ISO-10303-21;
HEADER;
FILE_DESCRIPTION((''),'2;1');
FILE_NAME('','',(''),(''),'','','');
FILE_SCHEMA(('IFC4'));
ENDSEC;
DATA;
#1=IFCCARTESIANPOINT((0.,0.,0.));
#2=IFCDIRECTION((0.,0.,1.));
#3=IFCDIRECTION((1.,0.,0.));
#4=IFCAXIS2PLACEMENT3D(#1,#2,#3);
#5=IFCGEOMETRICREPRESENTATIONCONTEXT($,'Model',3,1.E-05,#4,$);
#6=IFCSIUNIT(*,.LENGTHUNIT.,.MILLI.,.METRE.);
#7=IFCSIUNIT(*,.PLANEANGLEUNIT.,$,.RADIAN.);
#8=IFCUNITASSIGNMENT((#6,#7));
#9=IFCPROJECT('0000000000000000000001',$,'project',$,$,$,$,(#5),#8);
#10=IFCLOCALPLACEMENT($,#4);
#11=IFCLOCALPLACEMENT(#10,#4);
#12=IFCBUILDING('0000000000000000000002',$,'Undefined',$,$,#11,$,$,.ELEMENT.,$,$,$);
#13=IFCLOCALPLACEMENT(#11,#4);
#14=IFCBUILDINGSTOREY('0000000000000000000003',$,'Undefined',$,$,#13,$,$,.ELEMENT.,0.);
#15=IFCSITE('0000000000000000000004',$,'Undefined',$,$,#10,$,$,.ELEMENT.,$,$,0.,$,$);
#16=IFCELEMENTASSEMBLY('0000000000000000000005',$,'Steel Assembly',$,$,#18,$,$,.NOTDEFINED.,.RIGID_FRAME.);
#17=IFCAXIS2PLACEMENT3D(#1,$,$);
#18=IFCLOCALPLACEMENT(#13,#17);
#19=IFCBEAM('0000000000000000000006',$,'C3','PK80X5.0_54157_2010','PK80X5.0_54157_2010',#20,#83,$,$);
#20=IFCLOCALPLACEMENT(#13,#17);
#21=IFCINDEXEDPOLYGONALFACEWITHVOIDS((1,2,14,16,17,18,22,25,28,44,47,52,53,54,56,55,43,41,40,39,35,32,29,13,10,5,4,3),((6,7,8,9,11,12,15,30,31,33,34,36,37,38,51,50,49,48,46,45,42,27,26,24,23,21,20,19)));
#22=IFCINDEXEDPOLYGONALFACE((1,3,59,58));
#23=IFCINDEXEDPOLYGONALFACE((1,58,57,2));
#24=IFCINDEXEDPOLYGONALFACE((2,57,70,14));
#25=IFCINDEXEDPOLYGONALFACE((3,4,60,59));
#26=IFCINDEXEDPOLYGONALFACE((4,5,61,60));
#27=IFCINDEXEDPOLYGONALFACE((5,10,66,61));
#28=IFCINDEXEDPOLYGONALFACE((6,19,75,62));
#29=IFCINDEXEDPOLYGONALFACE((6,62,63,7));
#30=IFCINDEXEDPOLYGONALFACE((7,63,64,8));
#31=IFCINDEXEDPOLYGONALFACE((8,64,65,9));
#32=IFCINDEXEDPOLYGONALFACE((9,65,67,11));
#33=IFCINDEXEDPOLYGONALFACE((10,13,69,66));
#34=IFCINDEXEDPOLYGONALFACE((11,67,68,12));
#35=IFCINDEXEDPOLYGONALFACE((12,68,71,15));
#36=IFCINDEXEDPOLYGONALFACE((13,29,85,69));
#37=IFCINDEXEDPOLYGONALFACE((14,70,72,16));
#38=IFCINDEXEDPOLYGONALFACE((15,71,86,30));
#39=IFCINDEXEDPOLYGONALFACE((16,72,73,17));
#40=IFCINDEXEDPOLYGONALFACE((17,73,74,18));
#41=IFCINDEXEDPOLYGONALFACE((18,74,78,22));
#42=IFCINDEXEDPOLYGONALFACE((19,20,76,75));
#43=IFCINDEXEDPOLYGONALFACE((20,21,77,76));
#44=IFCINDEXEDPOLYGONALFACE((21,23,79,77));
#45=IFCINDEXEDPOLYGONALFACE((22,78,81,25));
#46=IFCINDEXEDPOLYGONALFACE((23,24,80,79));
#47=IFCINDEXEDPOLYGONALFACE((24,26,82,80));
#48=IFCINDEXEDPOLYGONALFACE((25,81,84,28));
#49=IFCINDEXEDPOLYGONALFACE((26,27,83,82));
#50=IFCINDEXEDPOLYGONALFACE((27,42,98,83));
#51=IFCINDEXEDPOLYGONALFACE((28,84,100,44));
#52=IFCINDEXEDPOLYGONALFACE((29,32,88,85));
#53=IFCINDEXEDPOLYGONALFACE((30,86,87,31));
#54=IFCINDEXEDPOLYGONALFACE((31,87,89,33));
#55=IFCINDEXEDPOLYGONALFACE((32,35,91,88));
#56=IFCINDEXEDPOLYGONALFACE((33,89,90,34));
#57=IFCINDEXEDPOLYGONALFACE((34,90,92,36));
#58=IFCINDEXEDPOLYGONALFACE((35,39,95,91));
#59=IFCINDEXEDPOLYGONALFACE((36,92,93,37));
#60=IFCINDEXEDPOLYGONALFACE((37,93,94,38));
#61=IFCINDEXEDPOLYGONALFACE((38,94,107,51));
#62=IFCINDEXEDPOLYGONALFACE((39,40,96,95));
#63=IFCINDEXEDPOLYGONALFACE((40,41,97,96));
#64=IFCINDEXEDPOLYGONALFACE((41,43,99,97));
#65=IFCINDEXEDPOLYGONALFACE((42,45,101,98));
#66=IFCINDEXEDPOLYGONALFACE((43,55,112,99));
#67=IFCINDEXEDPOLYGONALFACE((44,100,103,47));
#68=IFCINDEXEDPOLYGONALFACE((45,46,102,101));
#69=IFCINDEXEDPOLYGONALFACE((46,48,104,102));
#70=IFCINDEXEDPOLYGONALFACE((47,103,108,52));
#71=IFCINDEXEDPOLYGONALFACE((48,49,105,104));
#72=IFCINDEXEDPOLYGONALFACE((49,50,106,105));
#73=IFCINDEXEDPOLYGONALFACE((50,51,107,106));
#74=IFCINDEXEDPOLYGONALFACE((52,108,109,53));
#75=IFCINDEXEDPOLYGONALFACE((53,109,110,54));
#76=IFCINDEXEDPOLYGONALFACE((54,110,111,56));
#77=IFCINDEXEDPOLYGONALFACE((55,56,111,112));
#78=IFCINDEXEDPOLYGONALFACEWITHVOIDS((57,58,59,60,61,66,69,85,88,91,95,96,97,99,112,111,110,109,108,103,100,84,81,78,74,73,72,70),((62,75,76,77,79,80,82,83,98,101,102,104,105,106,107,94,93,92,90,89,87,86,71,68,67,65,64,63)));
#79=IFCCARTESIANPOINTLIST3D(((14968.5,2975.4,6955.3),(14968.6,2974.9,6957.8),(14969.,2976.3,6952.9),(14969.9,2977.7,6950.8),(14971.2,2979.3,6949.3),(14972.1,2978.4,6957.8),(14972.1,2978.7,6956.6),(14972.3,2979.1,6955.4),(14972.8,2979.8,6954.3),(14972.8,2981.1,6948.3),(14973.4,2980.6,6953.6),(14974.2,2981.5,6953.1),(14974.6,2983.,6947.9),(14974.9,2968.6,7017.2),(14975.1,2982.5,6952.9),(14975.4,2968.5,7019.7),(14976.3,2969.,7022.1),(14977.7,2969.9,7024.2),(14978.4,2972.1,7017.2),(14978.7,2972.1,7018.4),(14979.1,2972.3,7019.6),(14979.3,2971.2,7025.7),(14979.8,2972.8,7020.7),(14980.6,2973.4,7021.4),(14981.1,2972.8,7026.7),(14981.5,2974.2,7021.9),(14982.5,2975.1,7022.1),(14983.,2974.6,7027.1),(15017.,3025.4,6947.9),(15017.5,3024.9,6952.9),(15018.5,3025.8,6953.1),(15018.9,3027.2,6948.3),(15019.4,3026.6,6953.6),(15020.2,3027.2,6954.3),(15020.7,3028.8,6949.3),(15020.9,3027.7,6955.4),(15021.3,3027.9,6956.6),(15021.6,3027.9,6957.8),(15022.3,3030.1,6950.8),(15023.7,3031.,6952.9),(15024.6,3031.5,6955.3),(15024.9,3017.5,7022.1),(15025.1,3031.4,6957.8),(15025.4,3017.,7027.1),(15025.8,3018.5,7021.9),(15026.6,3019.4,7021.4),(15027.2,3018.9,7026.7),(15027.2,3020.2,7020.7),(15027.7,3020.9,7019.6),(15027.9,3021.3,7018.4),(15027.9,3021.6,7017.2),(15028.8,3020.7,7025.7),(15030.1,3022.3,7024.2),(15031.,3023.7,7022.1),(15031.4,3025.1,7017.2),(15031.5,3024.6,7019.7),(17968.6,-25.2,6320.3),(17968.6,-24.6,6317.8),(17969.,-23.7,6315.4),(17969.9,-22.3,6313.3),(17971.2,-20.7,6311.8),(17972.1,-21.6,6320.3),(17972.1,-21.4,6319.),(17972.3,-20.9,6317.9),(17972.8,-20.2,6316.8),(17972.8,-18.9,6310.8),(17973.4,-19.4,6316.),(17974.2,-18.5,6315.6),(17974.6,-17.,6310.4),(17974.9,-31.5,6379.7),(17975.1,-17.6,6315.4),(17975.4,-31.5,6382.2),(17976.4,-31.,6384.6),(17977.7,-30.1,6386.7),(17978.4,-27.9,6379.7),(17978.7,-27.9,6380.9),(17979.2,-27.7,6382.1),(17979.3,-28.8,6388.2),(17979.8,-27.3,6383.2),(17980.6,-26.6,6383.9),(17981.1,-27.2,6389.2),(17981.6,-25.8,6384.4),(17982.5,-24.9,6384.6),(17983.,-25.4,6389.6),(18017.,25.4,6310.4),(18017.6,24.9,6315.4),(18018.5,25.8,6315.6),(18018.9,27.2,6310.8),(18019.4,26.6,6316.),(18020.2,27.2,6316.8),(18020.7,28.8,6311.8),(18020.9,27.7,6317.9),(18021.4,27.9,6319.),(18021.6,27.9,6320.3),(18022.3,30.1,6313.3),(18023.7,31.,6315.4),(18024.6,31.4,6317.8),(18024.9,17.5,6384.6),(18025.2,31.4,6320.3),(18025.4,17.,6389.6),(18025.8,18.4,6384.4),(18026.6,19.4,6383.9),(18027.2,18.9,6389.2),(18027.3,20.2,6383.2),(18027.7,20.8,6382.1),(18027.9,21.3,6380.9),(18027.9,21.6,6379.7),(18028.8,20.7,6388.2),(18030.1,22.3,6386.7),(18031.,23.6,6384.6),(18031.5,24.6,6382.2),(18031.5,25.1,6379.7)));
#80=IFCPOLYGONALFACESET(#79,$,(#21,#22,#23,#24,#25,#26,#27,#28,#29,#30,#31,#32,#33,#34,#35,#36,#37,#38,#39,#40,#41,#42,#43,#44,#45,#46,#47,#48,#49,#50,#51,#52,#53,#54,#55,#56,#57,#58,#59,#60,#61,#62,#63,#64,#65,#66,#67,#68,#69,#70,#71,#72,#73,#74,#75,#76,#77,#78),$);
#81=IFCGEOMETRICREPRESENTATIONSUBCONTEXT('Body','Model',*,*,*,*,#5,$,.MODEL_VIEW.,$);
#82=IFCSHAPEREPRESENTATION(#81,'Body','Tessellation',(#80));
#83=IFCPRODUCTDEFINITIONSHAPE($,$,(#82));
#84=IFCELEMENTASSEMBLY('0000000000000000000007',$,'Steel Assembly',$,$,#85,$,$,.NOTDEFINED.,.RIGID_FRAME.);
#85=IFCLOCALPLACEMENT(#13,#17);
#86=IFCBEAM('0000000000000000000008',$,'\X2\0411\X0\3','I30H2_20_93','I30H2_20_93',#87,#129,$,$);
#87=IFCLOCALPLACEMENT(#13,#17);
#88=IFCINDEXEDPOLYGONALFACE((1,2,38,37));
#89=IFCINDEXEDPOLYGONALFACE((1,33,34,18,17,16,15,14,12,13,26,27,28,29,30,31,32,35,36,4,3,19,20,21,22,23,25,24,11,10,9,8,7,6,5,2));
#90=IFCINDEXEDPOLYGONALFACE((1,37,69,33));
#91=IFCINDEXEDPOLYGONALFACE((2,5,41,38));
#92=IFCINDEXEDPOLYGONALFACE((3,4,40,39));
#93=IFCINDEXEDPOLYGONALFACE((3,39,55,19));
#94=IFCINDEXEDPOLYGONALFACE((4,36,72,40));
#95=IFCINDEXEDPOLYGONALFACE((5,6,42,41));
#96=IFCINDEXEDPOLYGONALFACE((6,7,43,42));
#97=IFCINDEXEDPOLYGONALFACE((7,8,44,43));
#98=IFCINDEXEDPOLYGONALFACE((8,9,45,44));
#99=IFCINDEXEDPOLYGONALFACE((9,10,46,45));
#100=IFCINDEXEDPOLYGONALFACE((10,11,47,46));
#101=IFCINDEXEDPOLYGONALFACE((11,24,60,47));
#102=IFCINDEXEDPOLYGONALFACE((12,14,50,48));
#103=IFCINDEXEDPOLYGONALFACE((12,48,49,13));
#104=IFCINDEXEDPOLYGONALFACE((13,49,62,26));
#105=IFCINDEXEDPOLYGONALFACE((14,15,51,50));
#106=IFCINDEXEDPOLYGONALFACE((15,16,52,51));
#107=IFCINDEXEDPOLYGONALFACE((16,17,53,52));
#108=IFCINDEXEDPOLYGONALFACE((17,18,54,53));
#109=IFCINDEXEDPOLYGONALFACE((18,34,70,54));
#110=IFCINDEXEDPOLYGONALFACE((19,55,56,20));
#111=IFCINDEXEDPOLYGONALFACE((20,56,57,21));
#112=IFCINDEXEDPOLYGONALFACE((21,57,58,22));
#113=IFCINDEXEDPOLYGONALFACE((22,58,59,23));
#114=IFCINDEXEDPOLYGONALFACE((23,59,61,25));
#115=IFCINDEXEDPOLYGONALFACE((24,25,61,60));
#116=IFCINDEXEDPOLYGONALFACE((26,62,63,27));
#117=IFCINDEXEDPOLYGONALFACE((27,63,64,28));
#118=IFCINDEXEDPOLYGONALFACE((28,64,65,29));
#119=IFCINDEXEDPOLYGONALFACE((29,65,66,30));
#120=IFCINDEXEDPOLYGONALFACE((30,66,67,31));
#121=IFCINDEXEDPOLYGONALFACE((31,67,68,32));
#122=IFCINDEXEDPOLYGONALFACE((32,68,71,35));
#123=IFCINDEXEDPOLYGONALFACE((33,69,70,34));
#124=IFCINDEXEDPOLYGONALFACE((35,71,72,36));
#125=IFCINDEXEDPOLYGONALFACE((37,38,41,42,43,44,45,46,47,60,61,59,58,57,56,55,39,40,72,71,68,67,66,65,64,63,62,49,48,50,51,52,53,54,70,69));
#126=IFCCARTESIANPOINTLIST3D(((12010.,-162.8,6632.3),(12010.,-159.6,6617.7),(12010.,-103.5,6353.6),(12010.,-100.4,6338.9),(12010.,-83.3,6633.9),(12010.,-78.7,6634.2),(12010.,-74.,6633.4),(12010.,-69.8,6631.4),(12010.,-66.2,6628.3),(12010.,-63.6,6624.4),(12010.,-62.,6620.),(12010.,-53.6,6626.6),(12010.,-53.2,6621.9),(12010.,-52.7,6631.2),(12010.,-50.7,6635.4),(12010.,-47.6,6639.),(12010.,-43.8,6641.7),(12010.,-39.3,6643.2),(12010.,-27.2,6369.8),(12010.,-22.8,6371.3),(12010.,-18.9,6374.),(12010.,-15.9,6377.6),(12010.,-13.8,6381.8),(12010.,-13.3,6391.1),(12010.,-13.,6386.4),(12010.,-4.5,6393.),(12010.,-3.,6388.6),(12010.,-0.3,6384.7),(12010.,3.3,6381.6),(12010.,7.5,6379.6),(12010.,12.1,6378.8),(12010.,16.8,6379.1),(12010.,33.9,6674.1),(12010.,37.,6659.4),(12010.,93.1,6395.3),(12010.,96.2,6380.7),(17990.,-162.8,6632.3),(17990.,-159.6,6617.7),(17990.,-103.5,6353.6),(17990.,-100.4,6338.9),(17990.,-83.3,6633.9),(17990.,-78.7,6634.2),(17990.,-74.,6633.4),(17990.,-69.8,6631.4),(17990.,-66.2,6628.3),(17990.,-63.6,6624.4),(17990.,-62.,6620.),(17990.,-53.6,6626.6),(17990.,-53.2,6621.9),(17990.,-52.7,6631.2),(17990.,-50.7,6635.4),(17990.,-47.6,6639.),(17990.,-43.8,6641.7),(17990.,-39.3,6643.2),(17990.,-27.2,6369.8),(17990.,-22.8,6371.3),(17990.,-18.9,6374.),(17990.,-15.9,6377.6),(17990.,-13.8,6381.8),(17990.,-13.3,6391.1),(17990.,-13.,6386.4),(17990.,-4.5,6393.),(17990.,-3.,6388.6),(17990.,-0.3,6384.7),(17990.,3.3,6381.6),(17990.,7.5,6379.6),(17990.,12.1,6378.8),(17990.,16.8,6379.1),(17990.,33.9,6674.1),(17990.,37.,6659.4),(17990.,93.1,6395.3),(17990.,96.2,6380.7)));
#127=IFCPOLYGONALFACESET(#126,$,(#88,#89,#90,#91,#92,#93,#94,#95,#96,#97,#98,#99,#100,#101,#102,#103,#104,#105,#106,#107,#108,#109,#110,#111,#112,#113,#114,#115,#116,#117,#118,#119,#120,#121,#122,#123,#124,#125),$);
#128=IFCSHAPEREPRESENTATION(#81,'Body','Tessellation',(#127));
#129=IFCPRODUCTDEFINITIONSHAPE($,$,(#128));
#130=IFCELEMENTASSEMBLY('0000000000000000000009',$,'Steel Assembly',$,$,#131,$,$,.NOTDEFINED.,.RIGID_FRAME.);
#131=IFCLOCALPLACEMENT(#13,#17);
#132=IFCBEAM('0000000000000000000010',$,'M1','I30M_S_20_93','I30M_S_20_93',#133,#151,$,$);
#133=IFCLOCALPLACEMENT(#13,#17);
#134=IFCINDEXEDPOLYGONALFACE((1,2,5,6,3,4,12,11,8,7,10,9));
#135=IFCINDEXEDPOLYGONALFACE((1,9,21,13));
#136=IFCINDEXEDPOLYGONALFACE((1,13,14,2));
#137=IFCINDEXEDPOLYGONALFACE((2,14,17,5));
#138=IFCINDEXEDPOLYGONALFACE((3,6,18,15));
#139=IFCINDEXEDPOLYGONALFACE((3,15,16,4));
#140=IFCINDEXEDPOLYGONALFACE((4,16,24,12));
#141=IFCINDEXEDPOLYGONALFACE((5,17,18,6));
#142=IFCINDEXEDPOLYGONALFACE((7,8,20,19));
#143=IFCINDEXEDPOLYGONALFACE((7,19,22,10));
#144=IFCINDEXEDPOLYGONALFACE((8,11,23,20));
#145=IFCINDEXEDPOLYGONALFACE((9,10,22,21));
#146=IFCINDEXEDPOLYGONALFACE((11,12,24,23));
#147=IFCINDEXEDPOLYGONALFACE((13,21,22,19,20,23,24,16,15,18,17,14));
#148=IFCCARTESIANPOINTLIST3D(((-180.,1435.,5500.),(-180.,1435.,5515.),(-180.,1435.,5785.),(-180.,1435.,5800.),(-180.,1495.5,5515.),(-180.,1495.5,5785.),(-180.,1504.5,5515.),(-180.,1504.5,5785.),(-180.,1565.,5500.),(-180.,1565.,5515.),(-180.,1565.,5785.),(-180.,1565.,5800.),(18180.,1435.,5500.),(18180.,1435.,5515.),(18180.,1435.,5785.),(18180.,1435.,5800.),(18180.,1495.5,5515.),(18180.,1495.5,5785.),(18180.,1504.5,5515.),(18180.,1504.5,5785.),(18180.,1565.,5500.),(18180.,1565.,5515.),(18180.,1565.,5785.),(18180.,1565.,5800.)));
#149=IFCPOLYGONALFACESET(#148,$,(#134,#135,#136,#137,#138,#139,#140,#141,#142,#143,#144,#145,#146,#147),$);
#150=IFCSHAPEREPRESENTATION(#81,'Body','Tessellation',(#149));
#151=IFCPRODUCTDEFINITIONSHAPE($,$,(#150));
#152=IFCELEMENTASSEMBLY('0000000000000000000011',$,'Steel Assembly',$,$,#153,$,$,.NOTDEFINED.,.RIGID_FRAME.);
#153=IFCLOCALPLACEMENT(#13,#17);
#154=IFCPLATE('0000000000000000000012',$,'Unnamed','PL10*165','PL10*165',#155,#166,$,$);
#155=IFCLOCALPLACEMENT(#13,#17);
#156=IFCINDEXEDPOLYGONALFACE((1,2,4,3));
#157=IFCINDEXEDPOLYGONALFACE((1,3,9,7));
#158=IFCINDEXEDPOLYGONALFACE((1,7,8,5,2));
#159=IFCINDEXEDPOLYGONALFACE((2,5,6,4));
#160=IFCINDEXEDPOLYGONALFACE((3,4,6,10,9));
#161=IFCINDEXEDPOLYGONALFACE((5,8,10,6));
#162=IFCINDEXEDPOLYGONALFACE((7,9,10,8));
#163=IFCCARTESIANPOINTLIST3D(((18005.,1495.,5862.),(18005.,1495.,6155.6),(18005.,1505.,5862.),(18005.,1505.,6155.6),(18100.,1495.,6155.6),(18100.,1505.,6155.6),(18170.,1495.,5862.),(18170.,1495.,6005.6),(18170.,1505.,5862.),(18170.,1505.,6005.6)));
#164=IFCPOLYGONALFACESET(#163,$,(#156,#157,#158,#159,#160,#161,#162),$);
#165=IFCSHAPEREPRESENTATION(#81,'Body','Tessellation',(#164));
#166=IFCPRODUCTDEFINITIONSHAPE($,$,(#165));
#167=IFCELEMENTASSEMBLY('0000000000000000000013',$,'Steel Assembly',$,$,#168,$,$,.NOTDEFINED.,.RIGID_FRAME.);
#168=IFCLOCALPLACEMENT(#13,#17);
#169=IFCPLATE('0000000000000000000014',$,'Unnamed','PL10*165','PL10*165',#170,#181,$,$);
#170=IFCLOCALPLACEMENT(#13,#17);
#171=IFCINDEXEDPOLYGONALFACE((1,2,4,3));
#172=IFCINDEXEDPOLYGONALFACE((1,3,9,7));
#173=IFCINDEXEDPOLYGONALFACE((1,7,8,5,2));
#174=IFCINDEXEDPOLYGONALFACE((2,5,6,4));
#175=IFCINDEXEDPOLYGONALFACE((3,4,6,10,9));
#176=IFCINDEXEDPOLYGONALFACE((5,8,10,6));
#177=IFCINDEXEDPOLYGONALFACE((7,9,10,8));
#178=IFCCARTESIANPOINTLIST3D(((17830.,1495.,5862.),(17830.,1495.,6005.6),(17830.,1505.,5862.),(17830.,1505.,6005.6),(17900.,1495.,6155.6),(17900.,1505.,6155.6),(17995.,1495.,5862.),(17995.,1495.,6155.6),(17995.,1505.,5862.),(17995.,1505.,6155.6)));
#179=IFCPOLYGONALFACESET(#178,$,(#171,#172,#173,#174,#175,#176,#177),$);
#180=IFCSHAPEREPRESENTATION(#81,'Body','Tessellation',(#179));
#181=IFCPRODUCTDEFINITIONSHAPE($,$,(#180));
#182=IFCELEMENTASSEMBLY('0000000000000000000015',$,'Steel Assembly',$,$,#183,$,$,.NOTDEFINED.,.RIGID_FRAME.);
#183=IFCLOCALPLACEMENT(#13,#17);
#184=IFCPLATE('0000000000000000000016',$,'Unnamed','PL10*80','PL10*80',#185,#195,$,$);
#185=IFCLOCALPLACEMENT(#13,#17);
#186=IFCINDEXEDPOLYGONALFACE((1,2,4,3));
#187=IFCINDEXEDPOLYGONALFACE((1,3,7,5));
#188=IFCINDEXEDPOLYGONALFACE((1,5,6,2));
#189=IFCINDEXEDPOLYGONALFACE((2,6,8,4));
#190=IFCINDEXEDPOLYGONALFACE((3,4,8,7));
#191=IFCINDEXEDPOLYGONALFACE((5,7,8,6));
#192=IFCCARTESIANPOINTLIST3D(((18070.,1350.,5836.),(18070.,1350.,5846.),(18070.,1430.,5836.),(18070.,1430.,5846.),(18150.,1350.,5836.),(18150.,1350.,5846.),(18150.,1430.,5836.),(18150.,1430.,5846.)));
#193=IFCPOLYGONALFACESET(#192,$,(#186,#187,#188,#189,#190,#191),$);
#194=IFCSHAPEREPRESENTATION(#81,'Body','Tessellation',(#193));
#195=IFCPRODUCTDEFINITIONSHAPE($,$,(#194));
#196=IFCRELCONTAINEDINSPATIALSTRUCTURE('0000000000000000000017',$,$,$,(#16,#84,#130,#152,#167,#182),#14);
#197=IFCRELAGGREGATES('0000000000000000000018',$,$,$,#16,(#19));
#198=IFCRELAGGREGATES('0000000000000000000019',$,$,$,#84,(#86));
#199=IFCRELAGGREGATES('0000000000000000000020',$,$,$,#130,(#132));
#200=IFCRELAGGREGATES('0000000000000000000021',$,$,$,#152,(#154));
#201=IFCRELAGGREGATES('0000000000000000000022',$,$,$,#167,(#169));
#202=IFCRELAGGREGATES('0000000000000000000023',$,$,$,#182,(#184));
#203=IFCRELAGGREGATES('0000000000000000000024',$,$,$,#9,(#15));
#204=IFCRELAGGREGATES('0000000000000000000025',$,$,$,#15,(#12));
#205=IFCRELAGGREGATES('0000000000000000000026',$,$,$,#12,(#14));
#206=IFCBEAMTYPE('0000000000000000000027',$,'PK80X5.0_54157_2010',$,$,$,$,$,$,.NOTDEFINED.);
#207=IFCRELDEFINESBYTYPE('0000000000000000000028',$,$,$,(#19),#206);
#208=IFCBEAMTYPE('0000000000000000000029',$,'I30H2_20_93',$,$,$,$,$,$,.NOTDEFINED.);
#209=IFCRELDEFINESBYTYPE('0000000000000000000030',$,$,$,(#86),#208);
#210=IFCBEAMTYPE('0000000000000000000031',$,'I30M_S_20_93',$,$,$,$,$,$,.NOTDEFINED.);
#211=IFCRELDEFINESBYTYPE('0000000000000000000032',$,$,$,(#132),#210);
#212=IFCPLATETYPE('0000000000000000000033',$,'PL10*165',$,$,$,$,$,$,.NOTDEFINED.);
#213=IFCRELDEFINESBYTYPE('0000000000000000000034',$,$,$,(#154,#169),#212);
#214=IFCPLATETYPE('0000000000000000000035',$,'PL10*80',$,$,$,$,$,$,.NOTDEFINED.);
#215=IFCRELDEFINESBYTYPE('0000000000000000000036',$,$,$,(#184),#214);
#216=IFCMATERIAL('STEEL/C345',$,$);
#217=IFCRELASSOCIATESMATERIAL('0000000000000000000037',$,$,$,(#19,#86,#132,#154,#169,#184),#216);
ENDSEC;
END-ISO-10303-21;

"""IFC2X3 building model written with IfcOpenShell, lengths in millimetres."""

from ifc_helpers import new_model, si_unit, frame, origin_with_axes, origin_2d_with_axis, place, context, subcontext, project, spatial, polyline, hollow_rectangle, i_section, outline, extrude, material, type_object, element, aggregate, save


model = new_model("IFC2X3")

# Units and contexts
model_context = context("Model", 3, precision=1e-05, world=origin_with_axes())
body_context = subcontext(model_context, "Body", "Model", "MODEL_VIEW")
ifc_project = project(units=[si_unit("LENGTHUNIT", "METRE", prefix="MILLI"), si_unit("PLANEANGLEUNIT", "RADIAN")], contexts=[model_context])

# Site, building, storey
site_placement = place(None, origin_with_axes())
site = spatial("IfcSite", under=ifc_project, at=site_placement, Name="Undefined", CompositionType="ELEMENT", RefElevation=0.0)
building_placement = place(site_placement, origin_with_axes())
building = spatial("IfcBuilding", under=site, at=building_placement, Name="Undefined", CompositionType="ELEMENT")
storey_placement = place(building_placement, origin_with_axes())
storey = spatial("IfcBuildingStorey", under=building, at=storey_placement, Name="Undefined", CompositionType="ELEMENT", Elevation=0.0)

# Element assemblies, beams
ifc_material = material(Name="STEEL/C345")
assembly_1_placement = place(storey_placement, origin_with_axes())
assembly_1 = element("IfcElementAssembly", 1, at=assembly_1_placement, inside=storey, Name="Steel Assembly", AssemblyPlace="NOTDEFINED", PredefinedType="RIGID_FRAME")
beam_type_1 = type_object("IfcBeamType", Name="PK80X5.0_54157_2010", PredefinedType="NOTDEFINED")
beam_1_placement = place(assembly_1_placement, frame((18000.0, 0.0, 6350.0), z_axis=(0.10507, -0.10507, 0.988899), x_axis=(-0.699257, 0.699257, 0.148592)))
beam_1 = element("IfcBeam", 2, at=beam_1_placement, type_object=beam_type_1, material=ifc_material, Name="C3", Description="PK80X5.0_54157_2010", ObjectType="PK80X5.0_54157_2010", context=body_context, shape_type="SweptSolid", body=[
    extrude(hollow_rectangle(XDim=80.0, YDim=80.0, WallThickness=5.0, InnerFilletRadius=5.0, OuterFilletRadius=10.0, at=origin_2d_with_axis()), frame((4290.3, 0.0, 0.0), z_axis=(-1.0, 0.0, 0.0), x_axis=(0.0, -1.0, 0.0)), (0.0, 0.0, 1.0), 4290.3),
])
aggregate(assembly_1, [beam_1])
assembly_2_placement = place(storey_placement, origin_with_axes())
assembly_2 = element("IfcElementAssembly", 3, at=assembly_2_placement, inside=storey, Name="Steel Assembly", AssemblyPlace="NOTDEFINED", PredefinedType="RIGID_FRAME")
beam_type_2 = type_object("IfcBeamType", Name="I30H2_20_93", PredefinedType="NOTDEFINED")
beam_2_placement = place(assembly_2_placement, frame((17990.0, -33.3, 6506.5), z_axis=(0.0, 0.207912, -0.978148), x_axis=(-1.0, 0.0, 0.0)))
beam_2 = element("IfcBeam", 4, at=beam_2_placement, type_object=beam_type_2, material=ifc_material, Name="Б3", Description="I30H2_20_93", ObjectType="I30H2_20_93", context=body_context, shape_type="SweptSolid", body=[
    extrude(i_section(OverallWidth=201.0, OverallDepth=300.0, WebThickness=9.0, FlangeThickness=15.0, FilletRadius=18.0, at=origin_2d_with_axis()), frame((5980.0, 0.0, 0.0), z_axis=(-1.0, 0.0, 0.0), x_axis=(0.0, -1.0, 0.0)), (0.0, 0.0, 1.0), 5980.0),
])
aggregate(assembly_2, [beam_2])
assembly_3_placement = place(storey_placement, origin_with_axes())
assembly_3 = element("IfcElementAssembly", 5, at=assembly_3_placement, inside=storey, Name="Steel Assembly", AssemblyPlace="NOTDEFINED", PredefinedType="RIGID_FRAME")
beam_type_3 = type_object("IfcBeamType", Name="I30M_S_20_93", PredefinedType="NOTDEFINED")
beam_3_placement = place(assembly_3_placement, frame((18180.0, 1500.0, 5650.0), z_axis=(0.0, 0.0, 1.0), x_axis=(-1.0, 0.0, 0.0)))
beam_3 = element("IfcBeam", 6, at=beam_3_placement, type_object=beam_type_3, material=ifc_material, Name="M1", Description="I30M_S_20_93", ObjectType="I30M_S_20_93", context=body_context, shape_type="SweptSolid", body=[
    extrude(i_section(OverallWidth=130.0, OverallDepth=300.0, WebThickness=9.0, FlangeThickness=15.0, at=origin_2d_with_axis()), frame((18360.0, 0.0, 0.0), z_axis=(-1.0, 0.0, 0.0), x_axis=(0.0, -1.0, 0.0)), (0.0, 0.0, 1.0), 18360.0),
])
aggregate(assembly_3, [beam_3])

# Element assemblies, plates
assembly_4_placement = place(storey_placement, origin_with_axes())
assembly_4 = element("IfcElementAssembly", 7, at=assembly_4_placement, inside=storey, Name="Steel Assembly", AssemblyPlace="NOTDEFINED", PredefinedType="RIGID_FRAME")
plate_type_1 = type_object("IfcPlateType", Name="PL10*165", PredefinedType="NOTDEFINED")
plate_1_placement = place(assembly_4_placement, frame((18005.0, 1500.0, 5862.0), z_axis=(0.0, -1.0, 0.0), x_axis=(1.0, 0.0, 0.0)))
plate_1 = element("IfcPlate", 8, at=plate_1_placement, type_object=plate_type_1, material=ifc_material, Name="Unnamed", Description="PL10*165", ObjectType="PL10*165", context=body_context, shape_type="SweptSolid", body=[
    extrude(outline(polyline([(0.0, 0.0), (165.0, 0.0), (165.0, 143.6), (95.0, 293.6), (0.0, 293.6), (0.0, 0.0)])), frame((0.0, 0.0, -5.0), z_axis=(0.0, 0.0, 1.0), x_axis=(1.0, 0.0, 0.0)), (0.0, 0.0, 1.0), 10.0),
])
aggregate(assembly_4, [plate_1])
assembly_5_placement = place(storey_placement, origin_with_axes())
assembly_5 = element("IfcElementAssembly", 9, at=assembly_5_placement, inside=storey, Name="Steel Assembly", AssemblyPlace="NOTDEFINED", PredefinedType="RIGID_FRAME")
plate_2_placement = place(assembly_5_placement, frame((17995.0, 1500.0, 5862.0), z_axis=(0.0, 1.0, 0.0), x_axis=(-1.0, 0.0, 0.0)))
plate_2 = element("IfcPlate", 10, at=plate_2_placement, type_object=plate_type_1, material=ifc_material, Name="Unnamed", Description="PL10*165", ObjectType="PL10*165", context=body_context, shape_type="SweptSolid", body=[
    extrude(outline(polyline([(0.0, 0.0), (165.0, 0.0), (165.0, 143.6), (95.0, 293.6), (0.0, 293.6), (0.0, 0.0)])), frame((0.0, 0.0, -5.0), z_axis=(0.0, 0.0, 1.0), x_axis=(1.0, 0.0, 0.0)), (0.0, 0.0, 1.0), 10.0),
])
aggregate(assembly_5, [plate_2])
assembly_6_placement = place(storey_placement, origin_with_axes())
assembly_6 = element("IfcElementAssembly", 11, at=assembly_6_placement, inside=storey, Name="Steel Assembly", AssemblyPlace="NOTDEFINED", PredefinedType="RIGID_FRAME")
plate_type_2 = type_object("IfcPlateType", Name="PL10*80", PredefinedType="NOTDEFINED")
plate_3_placement = place(assembly_6_placement, frame((18150.0, 1350.0, 5841.0), z_axis=(0.0, 0.0, 1.0), x_axis=(0.0, 1.0, 0.0)))
plate_3 = element("IfcPlate", 12, at=plate_3_placement, type_object=plate_type_2, material=ifc_material, Name="Unnamed", Description="PL10*80", ObjectType="PL10*80", context=body_context, shape_type="SweptSolid", body=[
    extrude(outline(polyline([(0.0, 0.0), (80.0, 0.0), (80.0, 80.0), (0.0, 80.0), (0.0, 0.0)])), frame((0.0, 0.0, -5.0), z_axis=(0.0, 0.0, 1.0), x_axis=(1.0, 0.0, 0.0)), (0.0, 0.0, 1.0), 10.0),
])
aggregate(assembly_6, [plate_3])

save(model, "model.ifc")
